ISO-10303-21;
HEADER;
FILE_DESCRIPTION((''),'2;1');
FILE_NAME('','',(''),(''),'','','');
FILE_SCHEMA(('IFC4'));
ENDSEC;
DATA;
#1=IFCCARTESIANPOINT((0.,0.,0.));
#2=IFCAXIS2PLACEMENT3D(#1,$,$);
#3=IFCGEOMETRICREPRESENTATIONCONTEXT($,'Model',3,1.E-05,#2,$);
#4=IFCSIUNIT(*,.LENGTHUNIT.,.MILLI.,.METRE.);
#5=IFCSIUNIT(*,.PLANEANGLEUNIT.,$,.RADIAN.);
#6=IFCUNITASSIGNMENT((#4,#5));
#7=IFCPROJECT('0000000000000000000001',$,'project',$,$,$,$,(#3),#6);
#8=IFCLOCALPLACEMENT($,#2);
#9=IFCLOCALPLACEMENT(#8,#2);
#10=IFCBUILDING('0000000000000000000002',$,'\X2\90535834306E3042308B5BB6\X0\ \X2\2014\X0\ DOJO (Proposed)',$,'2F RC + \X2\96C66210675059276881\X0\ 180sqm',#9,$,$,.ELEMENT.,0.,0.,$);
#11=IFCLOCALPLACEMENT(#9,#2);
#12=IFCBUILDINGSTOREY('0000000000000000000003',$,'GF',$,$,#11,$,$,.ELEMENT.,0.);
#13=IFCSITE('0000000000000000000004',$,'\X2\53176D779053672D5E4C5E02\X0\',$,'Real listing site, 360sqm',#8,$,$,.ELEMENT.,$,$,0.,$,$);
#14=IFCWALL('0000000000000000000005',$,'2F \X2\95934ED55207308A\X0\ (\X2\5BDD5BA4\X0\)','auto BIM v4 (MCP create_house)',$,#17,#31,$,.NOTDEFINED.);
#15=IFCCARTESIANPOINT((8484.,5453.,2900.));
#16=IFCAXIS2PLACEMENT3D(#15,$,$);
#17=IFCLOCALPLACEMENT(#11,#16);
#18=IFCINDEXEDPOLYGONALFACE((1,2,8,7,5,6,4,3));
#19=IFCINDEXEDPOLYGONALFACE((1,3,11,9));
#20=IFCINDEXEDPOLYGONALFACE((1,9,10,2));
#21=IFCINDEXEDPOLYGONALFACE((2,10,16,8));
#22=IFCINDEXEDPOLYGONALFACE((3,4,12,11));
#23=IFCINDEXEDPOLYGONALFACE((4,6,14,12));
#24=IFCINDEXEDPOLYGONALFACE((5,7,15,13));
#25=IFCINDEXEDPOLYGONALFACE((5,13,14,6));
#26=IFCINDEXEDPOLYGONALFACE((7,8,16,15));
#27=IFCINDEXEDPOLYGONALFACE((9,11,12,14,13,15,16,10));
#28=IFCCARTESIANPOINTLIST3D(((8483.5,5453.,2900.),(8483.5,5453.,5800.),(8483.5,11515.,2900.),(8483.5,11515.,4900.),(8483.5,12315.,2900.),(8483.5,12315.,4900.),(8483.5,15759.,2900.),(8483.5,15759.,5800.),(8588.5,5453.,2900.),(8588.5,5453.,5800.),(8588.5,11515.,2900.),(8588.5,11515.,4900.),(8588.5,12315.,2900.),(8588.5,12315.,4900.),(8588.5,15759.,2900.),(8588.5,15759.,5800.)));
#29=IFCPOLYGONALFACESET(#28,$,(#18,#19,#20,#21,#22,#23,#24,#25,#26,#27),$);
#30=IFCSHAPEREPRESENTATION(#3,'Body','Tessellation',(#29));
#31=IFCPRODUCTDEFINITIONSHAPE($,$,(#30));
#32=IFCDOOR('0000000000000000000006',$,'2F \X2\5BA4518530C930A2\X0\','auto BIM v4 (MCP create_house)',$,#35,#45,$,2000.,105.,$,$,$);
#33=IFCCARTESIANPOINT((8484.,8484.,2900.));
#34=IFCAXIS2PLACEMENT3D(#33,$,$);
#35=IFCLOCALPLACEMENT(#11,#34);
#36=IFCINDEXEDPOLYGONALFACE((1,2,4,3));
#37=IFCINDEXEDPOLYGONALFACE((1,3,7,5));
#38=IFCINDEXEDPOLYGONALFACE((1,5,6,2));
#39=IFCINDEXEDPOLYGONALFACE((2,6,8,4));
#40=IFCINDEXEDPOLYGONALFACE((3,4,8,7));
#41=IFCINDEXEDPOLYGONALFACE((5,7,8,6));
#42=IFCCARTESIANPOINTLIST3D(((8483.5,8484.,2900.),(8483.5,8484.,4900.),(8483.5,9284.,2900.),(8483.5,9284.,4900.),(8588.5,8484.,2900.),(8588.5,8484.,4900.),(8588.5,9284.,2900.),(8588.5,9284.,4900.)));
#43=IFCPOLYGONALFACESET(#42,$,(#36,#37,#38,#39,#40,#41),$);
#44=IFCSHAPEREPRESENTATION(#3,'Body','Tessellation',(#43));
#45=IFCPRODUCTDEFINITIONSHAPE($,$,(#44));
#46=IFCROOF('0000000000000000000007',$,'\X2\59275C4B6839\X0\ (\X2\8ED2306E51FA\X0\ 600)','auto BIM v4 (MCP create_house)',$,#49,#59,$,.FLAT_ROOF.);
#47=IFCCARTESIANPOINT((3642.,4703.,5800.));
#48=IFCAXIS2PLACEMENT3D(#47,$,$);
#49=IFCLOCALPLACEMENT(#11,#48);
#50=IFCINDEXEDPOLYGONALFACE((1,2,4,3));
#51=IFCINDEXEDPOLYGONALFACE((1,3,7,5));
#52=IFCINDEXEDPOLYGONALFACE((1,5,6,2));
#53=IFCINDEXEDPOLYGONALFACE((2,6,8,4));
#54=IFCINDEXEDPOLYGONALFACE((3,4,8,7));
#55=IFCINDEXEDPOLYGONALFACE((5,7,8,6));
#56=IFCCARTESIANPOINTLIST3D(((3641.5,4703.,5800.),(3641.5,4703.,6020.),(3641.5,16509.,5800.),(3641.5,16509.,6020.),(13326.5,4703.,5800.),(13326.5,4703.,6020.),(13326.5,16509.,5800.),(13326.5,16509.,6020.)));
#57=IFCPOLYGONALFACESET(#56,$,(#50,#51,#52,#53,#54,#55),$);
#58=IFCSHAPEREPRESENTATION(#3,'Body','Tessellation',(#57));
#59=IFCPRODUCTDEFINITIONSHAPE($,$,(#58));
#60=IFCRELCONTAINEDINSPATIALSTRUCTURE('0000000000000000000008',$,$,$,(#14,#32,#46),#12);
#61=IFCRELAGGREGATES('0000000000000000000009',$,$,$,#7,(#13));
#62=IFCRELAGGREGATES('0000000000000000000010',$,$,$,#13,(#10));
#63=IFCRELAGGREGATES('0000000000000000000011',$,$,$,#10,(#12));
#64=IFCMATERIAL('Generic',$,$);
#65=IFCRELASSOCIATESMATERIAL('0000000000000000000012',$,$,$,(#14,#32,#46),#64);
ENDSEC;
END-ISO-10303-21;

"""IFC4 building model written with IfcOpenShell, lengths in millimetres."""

from ifc_helpers import new_model, si_unit, frame, frame_2d, origin, place, context, project, spatial, rectangle, extrude, material, element, fill, save


model = new_model("IFC4")

# Units and contexts
model_context = context("Model", 3, precision=1e-05, world=origin())
ifc_project = project(units=[si_unit("LENGTHUNIT", "METRE", prefix="MILLI"), si_unit("PLANEANGLEUNIT", "RADIAN")], contexts=[model_context])

# Site, building, storey
site_placement = place(None, origin())
site = spatial("IfcSite", under=ifc_project, at=site_placement, Name="北海道札幌市", ObjectType="Real listing site, 360sqm", CompositionType="ELEMENT", RefElevation=0.0)
building_placement = place(site_placement, origin())
building = spatial("IfcBuilding", under=site, at=building_placement, Name="道場のある家 — DOJO (Proposed)", ObjectType="2F RC + 集成材大梁 180sqm", CompositionType="ELEMENT", ElevationOfRefHeight=0.0, ElevationOfTerrain=0.0)
storey_placement = place(building_placement, origin())
storey = spatial("IfcBuildingStorey", under=building, at=storey_placement, Name="GF", CompositionType="ELEMENT", Elevation=0.0)

# Shared definitions
ifc_material = material(Name="Generic")

# Wall, opening, door
wall_1_placement = place(storey_placement, frame((8484.0, 5453.0, 2900.0)))
wall_1 = element("IfcWall", 1, at=wall_1_placement, inside=storey, material=ifc_material, Name="2F 間仕切り (寝室)", Description="auto BIM v4 (MCP create_house)", PredefinedType="NOTDEFINED", context=model_context, shape_type="SweptSolid", body=[
    extrude(rectangle(XDim=105.0, YDim=10306.0, at=frame_2d((52.0, 5153.0))), frame((8484.0, 5453.0, 2900.0)), (0.0, 0.0, 1.0), 2900.0),
])
opening_1_placement = place(storey_placement, frame((8484.0, 8484.0, 2900.0)))
opening_1 = element("IfcOpeningElement", 2, at=opening_1_placement, cuts=wall_1, PredefinedType="NOTDEFINED", context=model_context, shape_type="SweptSolid", body=[
    extrude(rectangle(XDim=105.0, YDim=800.0, at=frame_2d((52.0, 400.0))), frame((8484.0, 8484.0, 2900.0)), (0.0, 0.0, 1.0), 2000.0),
])
door_1_placement = place(storey_placement, frame((8484.0, 8484.0, 2900.0)))
door_1 = element("IfcDoor", 3, at=door_1_placement, inside=storey, material=ifc_material, Name="2F 室内ドア", Description="auto BIM v4 (MCP create_house)", OverallHeight=2000.0, OverallWidth=105.0, context=model_context, shape_type="SweptSolid", body=[
    extrude(rectangle(XDim=105.0, YDim=800.0, at=frame_2d((52.0, 400.0))), frame((8484.0, 8484.0, 2900.0)), (0.0, 0.0, 1.0), 2000.0),
])
fill(opening_1, door_1)

# Roof
roof_placement = place(storey_placement, frame((3642.0, 4703.0, 5800.0)))
element("IfcRoof", 4, at=roof_placement, inside=storey, material=ifc_material, Name="大屋根 (軒の出 600)", Description="auto BIM v4 (MCP create_house)", PredefinedType="FLAT_ROOF", context=model_context, shape_type="SweptSolid", body=[
    extrude(rectangle(XDim=9685.0, YDim=11806.0, at=frame_2d((4842.0, 5903.0))), frame((3642.0, 4703.0, 5800.0)), (0.0, 0.0, 1.0), 220.0),
])

save(model, "model.ifc")
